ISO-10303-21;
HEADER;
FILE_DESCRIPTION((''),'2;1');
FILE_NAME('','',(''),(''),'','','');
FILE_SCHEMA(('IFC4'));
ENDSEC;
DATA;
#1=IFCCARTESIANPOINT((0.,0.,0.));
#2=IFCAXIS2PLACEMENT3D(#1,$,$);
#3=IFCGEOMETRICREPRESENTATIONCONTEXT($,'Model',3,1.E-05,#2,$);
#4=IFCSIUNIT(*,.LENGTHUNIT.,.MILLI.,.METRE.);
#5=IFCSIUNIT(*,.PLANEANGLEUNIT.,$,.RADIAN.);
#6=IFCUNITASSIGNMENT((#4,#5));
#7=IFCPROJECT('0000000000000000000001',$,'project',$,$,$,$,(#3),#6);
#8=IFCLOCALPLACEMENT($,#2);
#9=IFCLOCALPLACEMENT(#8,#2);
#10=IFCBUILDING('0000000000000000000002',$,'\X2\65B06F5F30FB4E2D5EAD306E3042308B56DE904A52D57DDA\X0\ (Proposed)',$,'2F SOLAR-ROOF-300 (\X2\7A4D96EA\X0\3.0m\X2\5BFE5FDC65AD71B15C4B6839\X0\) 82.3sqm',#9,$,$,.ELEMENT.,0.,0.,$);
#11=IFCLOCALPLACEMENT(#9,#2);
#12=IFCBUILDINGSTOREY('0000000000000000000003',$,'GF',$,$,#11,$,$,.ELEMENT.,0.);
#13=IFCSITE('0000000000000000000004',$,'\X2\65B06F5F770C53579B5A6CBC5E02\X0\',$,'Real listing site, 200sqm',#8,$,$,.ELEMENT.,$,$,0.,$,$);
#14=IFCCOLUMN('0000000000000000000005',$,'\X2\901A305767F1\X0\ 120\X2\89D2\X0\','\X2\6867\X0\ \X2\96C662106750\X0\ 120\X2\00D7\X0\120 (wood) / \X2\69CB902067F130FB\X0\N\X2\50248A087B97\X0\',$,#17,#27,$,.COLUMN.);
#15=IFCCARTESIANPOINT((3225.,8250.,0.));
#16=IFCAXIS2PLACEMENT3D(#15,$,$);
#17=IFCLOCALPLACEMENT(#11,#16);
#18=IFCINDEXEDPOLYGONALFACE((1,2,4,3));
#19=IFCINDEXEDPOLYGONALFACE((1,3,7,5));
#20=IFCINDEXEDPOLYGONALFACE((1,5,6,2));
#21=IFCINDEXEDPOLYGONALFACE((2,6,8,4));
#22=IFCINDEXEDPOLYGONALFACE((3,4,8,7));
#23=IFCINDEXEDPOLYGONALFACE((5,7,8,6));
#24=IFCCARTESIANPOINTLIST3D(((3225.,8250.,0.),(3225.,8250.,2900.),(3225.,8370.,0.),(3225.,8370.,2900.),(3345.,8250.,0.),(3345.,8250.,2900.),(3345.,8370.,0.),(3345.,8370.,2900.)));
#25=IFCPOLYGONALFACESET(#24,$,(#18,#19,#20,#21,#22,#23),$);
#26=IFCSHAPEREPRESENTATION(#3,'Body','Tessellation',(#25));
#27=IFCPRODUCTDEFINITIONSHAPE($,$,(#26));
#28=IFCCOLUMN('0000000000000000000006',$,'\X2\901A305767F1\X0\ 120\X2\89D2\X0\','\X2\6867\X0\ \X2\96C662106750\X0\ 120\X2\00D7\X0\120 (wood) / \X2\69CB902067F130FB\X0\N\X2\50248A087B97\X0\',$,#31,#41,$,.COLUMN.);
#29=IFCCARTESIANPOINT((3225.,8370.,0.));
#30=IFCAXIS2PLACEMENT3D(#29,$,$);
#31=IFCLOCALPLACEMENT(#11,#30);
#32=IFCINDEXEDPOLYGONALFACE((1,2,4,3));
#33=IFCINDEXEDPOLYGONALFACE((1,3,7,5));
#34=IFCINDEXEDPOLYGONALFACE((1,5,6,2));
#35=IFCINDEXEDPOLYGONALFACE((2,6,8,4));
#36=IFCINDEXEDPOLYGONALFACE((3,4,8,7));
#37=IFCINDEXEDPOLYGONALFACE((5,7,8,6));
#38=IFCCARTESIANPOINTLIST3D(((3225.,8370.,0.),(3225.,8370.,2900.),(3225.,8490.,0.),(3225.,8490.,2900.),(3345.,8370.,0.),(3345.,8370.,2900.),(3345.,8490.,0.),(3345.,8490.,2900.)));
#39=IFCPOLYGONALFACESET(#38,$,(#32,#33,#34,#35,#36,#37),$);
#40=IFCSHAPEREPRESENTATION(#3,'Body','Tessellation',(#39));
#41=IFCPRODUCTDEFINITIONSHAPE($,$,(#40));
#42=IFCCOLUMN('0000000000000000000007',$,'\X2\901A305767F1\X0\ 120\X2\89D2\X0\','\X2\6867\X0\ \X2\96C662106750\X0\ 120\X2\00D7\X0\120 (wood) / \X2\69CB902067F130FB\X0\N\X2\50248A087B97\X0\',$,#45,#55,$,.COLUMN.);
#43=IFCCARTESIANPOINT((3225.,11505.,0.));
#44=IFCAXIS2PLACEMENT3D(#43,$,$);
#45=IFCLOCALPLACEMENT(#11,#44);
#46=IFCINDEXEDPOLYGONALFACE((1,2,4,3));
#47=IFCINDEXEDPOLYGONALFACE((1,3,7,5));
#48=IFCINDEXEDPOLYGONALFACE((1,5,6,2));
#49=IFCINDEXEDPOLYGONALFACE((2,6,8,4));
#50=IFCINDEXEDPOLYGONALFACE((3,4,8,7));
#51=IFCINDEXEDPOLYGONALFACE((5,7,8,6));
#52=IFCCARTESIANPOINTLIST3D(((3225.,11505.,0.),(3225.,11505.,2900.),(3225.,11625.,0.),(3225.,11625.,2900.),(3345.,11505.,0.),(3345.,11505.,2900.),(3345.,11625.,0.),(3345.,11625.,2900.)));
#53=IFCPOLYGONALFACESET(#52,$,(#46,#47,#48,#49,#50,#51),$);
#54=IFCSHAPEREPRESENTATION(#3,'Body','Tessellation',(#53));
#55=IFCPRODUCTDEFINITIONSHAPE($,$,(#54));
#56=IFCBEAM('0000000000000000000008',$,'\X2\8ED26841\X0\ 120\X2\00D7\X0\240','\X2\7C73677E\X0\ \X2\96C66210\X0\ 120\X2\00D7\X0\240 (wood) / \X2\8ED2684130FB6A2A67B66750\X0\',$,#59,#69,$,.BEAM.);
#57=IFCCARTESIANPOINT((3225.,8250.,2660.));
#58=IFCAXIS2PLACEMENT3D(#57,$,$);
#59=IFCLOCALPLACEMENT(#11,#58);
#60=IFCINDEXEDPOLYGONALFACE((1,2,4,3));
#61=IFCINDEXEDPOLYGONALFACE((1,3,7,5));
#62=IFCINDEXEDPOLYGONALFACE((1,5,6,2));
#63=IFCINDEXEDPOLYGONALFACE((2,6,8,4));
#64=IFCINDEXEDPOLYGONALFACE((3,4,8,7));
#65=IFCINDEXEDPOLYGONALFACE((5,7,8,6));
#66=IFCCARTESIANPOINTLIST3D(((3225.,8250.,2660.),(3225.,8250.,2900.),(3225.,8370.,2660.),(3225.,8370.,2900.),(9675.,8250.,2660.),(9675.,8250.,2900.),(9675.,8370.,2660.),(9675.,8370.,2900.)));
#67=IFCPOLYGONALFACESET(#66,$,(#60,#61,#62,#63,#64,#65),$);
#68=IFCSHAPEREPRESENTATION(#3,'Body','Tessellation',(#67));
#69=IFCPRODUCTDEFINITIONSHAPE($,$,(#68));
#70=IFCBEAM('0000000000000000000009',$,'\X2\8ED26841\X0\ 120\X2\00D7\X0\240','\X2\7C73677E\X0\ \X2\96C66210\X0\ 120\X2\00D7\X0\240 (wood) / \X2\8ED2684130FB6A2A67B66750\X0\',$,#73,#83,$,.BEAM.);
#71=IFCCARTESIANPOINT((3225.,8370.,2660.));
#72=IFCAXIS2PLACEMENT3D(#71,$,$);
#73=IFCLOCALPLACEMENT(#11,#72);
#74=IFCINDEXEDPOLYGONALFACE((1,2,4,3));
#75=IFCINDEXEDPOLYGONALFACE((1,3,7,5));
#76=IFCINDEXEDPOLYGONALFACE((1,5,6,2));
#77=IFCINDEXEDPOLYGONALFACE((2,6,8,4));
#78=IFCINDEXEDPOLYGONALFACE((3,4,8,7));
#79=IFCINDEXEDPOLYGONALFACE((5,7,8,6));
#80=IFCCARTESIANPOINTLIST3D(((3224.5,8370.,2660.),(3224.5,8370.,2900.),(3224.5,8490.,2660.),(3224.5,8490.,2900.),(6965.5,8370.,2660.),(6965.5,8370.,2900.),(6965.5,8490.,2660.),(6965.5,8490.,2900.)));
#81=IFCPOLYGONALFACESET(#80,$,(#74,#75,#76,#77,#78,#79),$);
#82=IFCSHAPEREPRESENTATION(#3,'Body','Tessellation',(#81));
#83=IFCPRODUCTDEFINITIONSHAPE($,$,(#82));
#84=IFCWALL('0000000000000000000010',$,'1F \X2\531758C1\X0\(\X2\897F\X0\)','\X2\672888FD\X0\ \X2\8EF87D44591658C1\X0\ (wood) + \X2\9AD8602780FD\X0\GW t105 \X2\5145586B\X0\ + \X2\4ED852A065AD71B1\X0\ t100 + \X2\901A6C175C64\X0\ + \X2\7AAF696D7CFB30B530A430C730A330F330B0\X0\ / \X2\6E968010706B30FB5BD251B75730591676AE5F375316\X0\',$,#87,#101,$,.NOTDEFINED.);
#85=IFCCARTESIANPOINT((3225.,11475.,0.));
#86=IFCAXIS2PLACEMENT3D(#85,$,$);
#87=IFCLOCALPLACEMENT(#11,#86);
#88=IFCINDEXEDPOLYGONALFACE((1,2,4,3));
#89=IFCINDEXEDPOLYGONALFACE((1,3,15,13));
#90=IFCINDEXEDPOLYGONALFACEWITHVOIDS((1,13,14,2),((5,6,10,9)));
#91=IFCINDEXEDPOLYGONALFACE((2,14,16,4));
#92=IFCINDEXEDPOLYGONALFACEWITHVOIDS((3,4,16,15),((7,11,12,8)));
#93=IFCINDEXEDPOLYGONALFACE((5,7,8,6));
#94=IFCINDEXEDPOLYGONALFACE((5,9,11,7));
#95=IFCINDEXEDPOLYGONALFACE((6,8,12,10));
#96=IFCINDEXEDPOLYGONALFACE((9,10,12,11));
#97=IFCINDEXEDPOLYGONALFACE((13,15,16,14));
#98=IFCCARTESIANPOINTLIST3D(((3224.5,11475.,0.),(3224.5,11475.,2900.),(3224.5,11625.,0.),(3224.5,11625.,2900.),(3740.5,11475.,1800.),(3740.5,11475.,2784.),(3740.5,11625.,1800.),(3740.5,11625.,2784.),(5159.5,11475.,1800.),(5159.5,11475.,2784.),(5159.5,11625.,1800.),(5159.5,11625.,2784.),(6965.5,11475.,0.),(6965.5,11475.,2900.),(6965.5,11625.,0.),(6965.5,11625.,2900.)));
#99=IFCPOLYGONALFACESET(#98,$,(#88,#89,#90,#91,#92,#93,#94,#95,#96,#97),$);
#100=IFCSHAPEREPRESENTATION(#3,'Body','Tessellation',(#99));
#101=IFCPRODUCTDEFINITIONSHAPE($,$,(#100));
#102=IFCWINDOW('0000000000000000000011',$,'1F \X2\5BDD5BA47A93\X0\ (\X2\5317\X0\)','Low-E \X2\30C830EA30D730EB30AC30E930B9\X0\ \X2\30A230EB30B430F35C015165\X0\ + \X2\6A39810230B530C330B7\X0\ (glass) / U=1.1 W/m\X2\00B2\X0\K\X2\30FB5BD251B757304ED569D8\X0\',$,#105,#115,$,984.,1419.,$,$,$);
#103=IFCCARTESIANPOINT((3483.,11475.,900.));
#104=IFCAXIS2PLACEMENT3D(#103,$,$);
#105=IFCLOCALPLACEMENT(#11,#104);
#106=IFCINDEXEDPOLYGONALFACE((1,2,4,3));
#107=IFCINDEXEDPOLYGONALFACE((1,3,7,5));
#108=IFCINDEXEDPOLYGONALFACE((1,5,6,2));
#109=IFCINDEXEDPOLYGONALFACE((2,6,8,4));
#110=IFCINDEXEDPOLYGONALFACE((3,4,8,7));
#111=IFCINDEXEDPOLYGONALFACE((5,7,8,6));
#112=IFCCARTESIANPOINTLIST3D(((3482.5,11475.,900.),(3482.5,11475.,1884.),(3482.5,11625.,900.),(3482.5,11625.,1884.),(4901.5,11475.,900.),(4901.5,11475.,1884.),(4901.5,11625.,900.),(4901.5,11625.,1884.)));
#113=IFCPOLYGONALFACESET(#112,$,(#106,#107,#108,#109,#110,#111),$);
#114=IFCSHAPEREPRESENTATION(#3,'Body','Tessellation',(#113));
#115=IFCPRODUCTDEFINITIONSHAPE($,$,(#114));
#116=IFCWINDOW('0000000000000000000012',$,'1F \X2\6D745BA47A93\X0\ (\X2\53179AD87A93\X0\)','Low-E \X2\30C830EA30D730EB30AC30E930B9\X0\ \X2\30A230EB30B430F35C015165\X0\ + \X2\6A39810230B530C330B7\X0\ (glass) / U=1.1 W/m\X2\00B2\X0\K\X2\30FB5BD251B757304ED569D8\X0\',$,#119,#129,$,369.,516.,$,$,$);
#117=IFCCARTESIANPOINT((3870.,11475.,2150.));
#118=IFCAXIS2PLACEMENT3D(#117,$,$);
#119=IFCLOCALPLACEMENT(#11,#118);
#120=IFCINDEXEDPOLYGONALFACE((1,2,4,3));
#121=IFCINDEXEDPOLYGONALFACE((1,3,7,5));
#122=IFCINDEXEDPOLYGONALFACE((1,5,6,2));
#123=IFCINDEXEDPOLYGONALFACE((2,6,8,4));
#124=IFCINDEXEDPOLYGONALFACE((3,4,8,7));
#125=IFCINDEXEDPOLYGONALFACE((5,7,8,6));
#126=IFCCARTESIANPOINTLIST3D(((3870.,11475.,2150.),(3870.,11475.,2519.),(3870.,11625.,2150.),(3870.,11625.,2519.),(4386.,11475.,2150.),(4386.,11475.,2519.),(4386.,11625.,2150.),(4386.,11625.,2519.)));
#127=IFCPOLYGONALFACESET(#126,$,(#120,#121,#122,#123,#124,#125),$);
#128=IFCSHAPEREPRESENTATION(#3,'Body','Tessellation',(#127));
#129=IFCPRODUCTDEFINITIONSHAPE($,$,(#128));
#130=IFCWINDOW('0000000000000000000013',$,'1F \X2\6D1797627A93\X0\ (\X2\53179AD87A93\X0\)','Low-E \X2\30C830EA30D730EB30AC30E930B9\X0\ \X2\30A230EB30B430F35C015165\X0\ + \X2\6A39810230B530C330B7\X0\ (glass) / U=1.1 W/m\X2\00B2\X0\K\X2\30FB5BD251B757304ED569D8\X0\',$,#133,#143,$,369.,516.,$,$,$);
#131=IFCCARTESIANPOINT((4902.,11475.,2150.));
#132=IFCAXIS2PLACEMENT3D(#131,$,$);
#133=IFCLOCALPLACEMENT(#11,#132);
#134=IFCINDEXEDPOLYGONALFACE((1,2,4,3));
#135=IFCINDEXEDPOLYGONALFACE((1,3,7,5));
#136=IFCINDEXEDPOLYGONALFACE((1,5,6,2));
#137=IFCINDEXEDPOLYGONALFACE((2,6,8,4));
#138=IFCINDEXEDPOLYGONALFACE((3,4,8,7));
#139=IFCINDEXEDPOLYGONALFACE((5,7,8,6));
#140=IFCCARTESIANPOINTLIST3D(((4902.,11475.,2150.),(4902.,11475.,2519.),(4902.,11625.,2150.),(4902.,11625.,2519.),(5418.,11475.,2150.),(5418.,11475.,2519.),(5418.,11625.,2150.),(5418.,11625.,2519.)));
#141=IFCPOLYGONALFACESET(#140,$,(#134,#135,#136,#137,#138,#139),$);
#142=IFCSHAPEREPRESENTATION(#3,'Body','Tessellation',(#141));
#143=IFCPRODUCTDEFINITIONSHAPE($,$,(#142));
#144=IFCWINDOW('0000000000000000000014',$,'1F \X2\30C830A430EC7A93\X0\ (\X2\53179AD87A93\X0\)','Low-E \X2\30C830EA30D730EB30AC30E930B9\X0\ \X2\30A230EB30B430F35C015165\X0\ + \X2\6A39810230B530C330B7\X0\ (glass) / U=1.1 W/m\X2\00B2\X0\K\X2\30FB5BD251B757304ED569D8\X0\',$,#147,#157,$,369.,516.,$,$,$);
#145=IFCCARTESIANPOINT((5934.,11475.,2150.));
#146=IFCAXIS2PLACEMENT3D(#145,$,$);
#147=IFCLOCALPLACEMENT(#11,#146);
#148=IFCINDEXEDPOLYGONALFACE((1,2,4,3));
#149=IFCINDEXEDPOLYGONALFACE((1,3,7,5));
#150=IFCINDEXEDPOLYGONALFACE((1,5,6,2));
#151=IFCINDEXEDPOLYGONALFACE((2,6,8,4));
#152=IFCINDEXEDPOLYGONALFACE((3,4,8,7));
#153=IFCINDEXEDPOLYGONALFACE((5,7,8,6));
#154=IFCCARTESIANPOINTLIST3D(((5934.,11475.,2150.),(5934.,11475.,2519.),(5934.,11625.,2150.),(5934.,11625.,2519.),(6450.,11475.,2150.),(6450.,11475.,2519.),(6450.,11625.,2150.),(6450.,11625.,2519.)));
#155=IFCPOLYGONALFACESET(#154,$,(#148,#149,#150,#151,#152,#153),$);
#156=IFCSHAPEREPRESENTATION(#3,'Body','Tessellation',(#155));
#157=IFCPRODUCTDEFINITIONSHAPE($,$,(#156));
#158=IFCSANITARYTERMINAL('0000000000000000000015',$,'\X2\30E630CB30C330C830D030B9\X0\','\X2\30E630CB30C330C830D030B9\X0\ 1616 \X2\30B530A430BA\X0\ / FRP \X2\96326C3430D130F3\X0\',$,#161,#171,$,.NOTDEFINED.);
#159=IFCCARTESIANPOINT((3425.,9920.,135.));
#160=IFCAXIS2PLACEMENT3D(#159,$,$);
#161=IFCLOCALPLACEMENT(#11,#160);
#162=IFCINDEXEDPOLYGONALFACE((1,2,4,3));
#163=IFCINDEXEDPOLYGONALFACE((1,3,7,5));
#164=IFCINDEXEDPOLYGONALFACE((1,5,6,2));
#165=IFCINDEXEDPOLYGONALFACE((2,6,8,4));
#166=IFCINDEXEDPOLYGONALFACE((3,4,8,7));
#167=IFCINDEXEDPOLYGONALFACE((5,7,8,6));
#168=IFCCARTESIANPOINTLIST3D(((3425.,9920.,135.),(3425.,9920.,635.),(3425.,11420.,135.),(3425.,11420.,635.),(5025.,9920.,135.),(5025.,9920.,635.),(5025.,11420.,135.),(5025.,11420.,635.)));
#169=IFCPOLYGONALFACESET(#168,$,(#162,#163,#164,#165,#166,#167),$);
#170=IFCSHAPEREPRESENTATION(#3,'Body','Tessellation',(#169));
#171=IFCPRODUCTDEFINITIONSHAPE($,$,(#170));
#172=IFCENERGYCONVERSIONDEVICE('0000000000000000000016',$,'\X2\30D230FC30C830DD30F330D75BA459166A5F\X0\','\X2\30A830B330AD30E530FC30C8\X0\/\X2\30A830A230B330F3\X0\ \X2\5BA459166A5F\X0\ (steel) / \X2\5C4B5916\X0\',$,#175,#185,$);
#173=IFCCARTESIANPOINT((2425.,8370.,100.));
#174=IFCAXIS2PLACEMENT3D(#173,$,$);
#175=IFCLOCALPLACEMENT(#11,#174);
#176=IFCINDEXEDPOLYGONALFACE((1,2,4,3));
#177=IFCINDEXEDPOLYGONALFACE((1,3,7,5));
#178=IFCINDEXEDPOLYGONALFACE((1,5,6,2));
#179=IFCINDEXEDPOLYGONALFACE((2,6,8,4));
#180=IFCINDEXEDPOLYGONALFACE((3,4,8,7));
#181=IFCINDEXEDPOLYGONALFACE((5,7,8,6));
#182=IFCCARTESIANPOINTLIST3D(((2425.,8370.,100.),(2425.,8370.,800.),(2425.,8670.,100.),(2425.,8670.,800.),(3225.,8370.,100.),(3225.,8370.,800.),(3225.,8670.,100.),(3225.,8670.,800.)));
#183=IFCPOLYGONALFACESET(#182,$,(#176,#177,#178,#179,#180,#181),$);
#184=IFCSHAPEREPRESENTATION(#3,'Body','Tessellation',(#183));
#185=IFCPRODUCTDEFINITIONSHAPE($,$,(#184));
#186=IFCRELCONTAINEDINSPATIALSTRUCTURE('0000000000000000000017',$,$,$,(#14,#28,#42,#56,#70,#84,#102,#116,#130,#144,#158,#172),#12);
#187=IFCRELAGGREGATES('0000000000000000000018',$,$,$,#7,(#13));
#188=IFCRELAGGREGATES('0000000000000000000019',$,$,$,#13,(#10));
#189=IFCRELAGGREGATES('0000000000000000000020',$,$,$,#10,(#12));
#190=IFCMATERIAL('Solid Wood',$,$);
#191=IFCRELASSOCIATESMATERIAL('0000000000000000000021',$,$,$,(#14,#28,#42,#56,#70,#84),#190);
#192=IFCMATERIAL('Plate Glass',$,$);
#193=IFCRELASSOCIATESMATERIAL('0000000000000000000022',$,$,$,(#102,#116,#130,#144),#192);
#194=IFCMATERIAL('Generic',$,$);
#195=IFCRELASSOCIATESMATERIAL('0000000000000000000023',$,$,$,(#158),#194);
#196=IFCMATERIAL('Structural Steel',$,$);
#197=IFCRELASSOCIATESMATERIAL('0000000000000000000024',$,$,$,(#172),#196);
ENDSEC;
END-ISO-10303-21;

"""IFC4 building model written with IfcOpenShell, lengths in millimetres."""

from ifc_helpers import new_model, si_unit, frame, frame_2d, origin, place, context, project, spatial, rectangle, extrude, material, element, fill, save


model = new_model("IFC4")

# Units and contexts
model_context = context("Model", 3, precision=1e-05, world=origin())
ifc_project = project(units=[si_unit("LENGTHUNIT", "METRE", prefix="MILLI"), si_unit("PLANEANGLEUNIT", "RADIAN")], contexts=[model_context])

# Site, building, storey
site_placement = place(None, origin())
site = spatial("IfcSite", under=ifc_project, at=site_placement, Name="新潟県南魚沼市", ObjectType="Real listing site, 200sqm", CompositionType="ELEMENT", RefElevation=0.0)
building_placement = place(site_placement, origin())
building = spatial("IfcBuilding", under=site, at=building_placement, Name="新潟・中庭のある回遊動線 (Proposed)", ObjectType="2F SOLAR-ROOF-300 (積雪3.0m対応断熱屋根) 82.3sqm", CompositionType="ELEMENT", ElevationOfRefHeight=0.0, ElevationOfTerrain=0.0)
storey_placement = place(building_placement, origin())
storey = spatial("IfcBuildingStorey", under=building, at=storey_placement, Name="GF", CompositionType="ELEMENT", Elevation=0.0)

# Columns
ifc_material_1 = material(Name="Solid Wood")
column_1_placement = place(storey_placement, frame((3225.0, 8250.0, 0.0)))
element("IfcColumn", 1, at=column_1_placement, inside=storey, material=ifc_material_1, Name="通し柱 120角", Description="桧 集成材 120×120 (wood) / 構造柱・N値計算", PredefinedType="COLUMN", context=model_context, shape_type="SweptSolid", body=[
    extrude(rectangle(XDim=120.0, YDim=120.0, at=frame_2d((60.0, 60.0))), frame((3225.0, 8250.0, 0.0)), (0.0, 0.0, 1.0), 2900.0),
])
column_2_placement = place(storey_placement, frame((3225.0, 8370.0, 0.0)))
element("IfcColumn", 2, at=column_2_placement, inside=storey, material=ifc_material_1, Name="通し柱 120角", Description="桧 集成材 120×120 (wood) / 構造柱・N値計算", PredefinedType="COLUMN", context=model_context, shape_type="SweptSolid", body=[
    extrude(rectangle(XDim=120.0, YDim=120.0, at=frame_2d((60.0, 60.0))), frame((3225.0, 8370.0, 0.0)), (0.0, 0.0, 1.0), 2900.0),
])
column_3_placement = place(storey_placement, frame((3225.0, 11505.0, 0.0)))
element("IfcColumn", 3, at=column_3_placement, inside=storey, material=ifc_material_1, Name="通し柱 120角", Description="桧 集成材 120×120 (wood) / 構造柱・N値計算", PredefinedType="COLUMN", context=model_context, shape_type="SweptSolid", body=[
    extrude(rectangle(XDim=120.0, YDim=120.0, at=frame_2d((60.0, 60.0))), frame((3225.0, 11505.0, 0.0)), (0.0, 0.0, 1.0), 2900.0),
])

# Beams
beam_1_placement = place(storey_placement, frame((3225.0, 8250.0, 2660.0)))
element("IfcBeam", 4, at=beam_1_placement, inside=storey, material=ifc_material_1, Name="軒桁 120×240", Description="米松 集成 120×240 (wood) / 軒桁・横架材", PredefinedType="BEAM", context=model_context, shape_type="SweptSolid", body=[
    extrude(rectangle(XDim=6450.0, YDim=120.0, at=frame_2d((3225.0, 60.0))), frame((3225.0, 8250.0, 2660.0)), (0.0, 0.0, 1.0), 240.0),
])
beam_2_placement = place(storey_placement, frame((3225.0, 8370.0, 2660.0)))
element("IfcBeam", 5, at=beam_2_placement, inside=storey, material=ifc_material_1, Name="軒桁 120×240", Description="米松 集成 120×240 (wood) / 軒桁・横架材", PredefinedType="BEAM", context=model_context, shape_type="SweptSolid", body=[
    extrude(rectangle(XDim=3741.0, YDim=120.0, at=frame_2d((1870.0, 60.0))), frame((3225.0, 8370.0, 2660.0)), (0.0, 0.0, 1.0), 240.0),
])

# Wall, openings, windows
wall_1_placement = place(storey_placement, frame((3225.0, 11475.0, 0.0)))
wall_1 = element("IfcWall", 6, at=wall_1_placement, inside=storey, material=ifc_material_1, Name="1F 北壁(西)", Description="木製 軸組外壁 (wood) + 高性能GW t105 充填 + 付加断熱 t100 + 通気層 + 窯業系サイディング / 準耐火・寒冷地外皮強化", PredefinedType="NOTDEFINED", context=model_context, shape_type="SweptSolid", body=[
    extrude(rectangle(XDim=3741.0, YDim=150.0, at=frame_2d((1870.0, 75.0))), frame((3225.0, 11475.0, 0.0)), (0.0, 0.0, 1.0), 2900.0),
])
opening_1_placement = place(storey_placement, frame((3483.0, 11475.0, 900.0)))
opening_1 = element("IfcOpeningElement", 7, at=opening_1_placement, cuts=wall_1, PredefinedType="NOTDEFINED", context=model_context, shape_type="SweptSolid", body=[
    extrude(rectangle(XDim=1419.0, YDim=150.0, at=frame_2d((709.0, 75.0))), frame((3483.0, 11475.0, 900.0)), (0.0, 0.0, 1.0), 984.0),
])
opening_2_placement = place(storey_placement, frame((3870.0, 11475.0, 2150.0)))
opening_2 = element("IfcOpeningElement", 8, at=opening_2_placement, cuts=wall_1, PredefinedType="NOTDEFINED", context=model_context, shape_type="SweptSolid", body=[
    extrude(rectangle(XDim=516.0, YDim=150.0, at=frame_2d((258.0, 75.0))), frame((3870.0, 11475.0, 2150.0)), (0.0, 0.0, 1.0), 369.0),
])
opening_3_placement = place(storey_placement, frame((4902.0, 11475.0, 2150.0)))
opening_3 = element("IfcOpeningElement", 9, at=opening_3_placement, cuts=wall_1, PredefinedType="NOTDEFINED", context=model_context, shape_type="SweptSolid", body=[
    extrude(rectangle(XDim=516.0, YDim=150.0, at=frame_2d((258.0, 75.0))), frame((4902.0, 11475.0, 2150.0)), (0.0, 0.0, 1.0), 369.0),
])
opening_4_placement = place(storey_placement, frame((5934.0, 11475.0, 2150.0)))
opening_4 = element("IfcOpeningElement", 10, at=opening_4_placement, cuts=wall_1, PredefinedType="NOTDEFINED", context=model_context, shape_type="SweptSolid", body=[
    extrude(rectangle(XDim=516.0, YDim=150.0, at=frame_2d((258.0, 75.0))), frame((5934.0, 11475.0, 2150.0)), (0.0, 0.0, 1.0), 369.0),
])
ifc_material_2 = material(Name="Plate Glass")
window_1_placement = place(storey_placement, frame((3483.0, 11475.0, 900.0)))
window_1 = element("IfcWindow", 11, at=window_1_placement, inside=storey, material=ifc_material_2, Name="1F 寝室窓 (北)", Description="Low-E トリプルガラス アルゴン封入 + 樹脂サッシ (glass) / U=1.1 W/m²K・寒冷地仕様", OverallHeight=984.0, OverallWidth=1419.0, context=model_context, shape_type="SweptSolid", body=[
    extrude(rectangle(XDim=1419.0, YDim=150.0, at=frame_2d((709.0, 75.0))), frame((3483.0, 11475.0, 900.0)), (0.0, 0.0, 1.0), 984.0),
])
fill(opening_1, window_1)
window_2_placement = place(storey_placement, frame((3870.0, 11475.0, 2150.0)))
window_2 = element("IfcWindow", 12, at=window_2_placement, inside=storey, material=ifc_material_2, Name="1F 浴室窓 (北高窓)", Description="Low-E トリプルガラス アルゴン封入 + 樹脂サッシ (glass) / U=1.1 W/m²K・寒冷地仕様", OverallHeight=369.0, OverallWidth=516.0, context=model_context, shape_type="SweptSolid", body=[
    extrude(rectangle(XDim=516.0, YDim=150.0, at=frame_2d((258.0, 75.0))), frame((3870.0, 11475.0, 2150.0)), (0.0, 0.0, 1.0), 369.0),
])
fill(opening_2, window_2)
window_3_placement = place(storey_placement, frame((4902.0, 11475.0, 2150.0)))
window_3 = element("IfcWindow", 13, at=window_3_placement, inside=storey, material=ifc_material_2, Name="1F 洗面窓 (北高窓)", Description="Low-E トリプルガラス アルゴン封入 + 樹脂サッシ (glass) / U=1.1 W/m²K・寒冷地仕様", OverallHeight=369.0, OverallWidth=516.0, context=model_context, shape_type="SweptSolid", body=[
    extrude(rectangle(XDim=516.0, YDim=150.0, at=frame_2d((258.0, 75.0))), frame((4902.0, 11475.0, 2150.0)), (0.0, 0.0, 1.0), 369.0),
])
fill(opening_3, window_3)
window_4_placement = place(storey_placement, frame((5934.0, 11475.0, 2150.0)))
window_4 = element("IfcWindow", 14, at=window_4_placement, inside=storey, material=ifc_material_2, Name="1F トイレ窓 (北高窓)", Description="Low-E トリプルガラス アルゴン封入 + 樹脂サッシ (glass) / U=1.1 W/m²K・寒冷地仕様", OverallHeight=369.0, OverallWidth=516.0, context=model_context, shape_type="SweptSolid", body=[
    extrude(rectangle(XDim=516.0, YDim=150.0, at=frame_2d((258.0, 75.0))), frame((5934.0, 11475.0, 2150.0)), (0.0, 0.0, 1.0), 369.0),
])
fill(opening_4, window_4)

# Shared definitions
ifc_material_3 = material(Name="Generic")

# Sanitary terminal
sanitary_terminal_placement = place(storey_placement, frame((3425.0, 9920.0, 135.0)))
element("IfcSanitaryTerminal", 15, at=sanitary_terminal_placement, inside=storey, material=ifc_material_3, Name="ユニットバス", Description="ユニットバス 1616 サイズ / FRP 防水パン", PredefinedType="NOTDEFINED", context=model_context, shape_type="SweptSolid", body=[
    extrude(rectangle(XDim=1600.0, YDim=1500.0, at=frame_2d((800.0, 750.0))), frame((3425.0, 9920.0, 135.0)), (0.0, 0.0, 1.0), 500.0),
])

# Energy conversion device
ifc_material_4 = material(Name="Structural Steel")
energy_conversion_device_placement = place(storey_placement, frame((2425.0, 8370.0, 100.0)))
element("IfcEnergyConversionDevice", 16, at=energy_conversion_device_placement, inside=storey, material=ifc_material_4, Name="ヒートポンプ室外機", Description="エコキュート/エアコン 室外機 (steel) / 屋外", context=model_context, shape_type="SweptSolid", body=[
    extrude(rectangle(XDim=800.0, YDim=300.0, at=frame_2d((400.0, 150.0))), frame((2425.0, 8370.0, 100.0)), (0.0, 0.0, 1.0), 700.0),
])

save(model, "model.ifc")
